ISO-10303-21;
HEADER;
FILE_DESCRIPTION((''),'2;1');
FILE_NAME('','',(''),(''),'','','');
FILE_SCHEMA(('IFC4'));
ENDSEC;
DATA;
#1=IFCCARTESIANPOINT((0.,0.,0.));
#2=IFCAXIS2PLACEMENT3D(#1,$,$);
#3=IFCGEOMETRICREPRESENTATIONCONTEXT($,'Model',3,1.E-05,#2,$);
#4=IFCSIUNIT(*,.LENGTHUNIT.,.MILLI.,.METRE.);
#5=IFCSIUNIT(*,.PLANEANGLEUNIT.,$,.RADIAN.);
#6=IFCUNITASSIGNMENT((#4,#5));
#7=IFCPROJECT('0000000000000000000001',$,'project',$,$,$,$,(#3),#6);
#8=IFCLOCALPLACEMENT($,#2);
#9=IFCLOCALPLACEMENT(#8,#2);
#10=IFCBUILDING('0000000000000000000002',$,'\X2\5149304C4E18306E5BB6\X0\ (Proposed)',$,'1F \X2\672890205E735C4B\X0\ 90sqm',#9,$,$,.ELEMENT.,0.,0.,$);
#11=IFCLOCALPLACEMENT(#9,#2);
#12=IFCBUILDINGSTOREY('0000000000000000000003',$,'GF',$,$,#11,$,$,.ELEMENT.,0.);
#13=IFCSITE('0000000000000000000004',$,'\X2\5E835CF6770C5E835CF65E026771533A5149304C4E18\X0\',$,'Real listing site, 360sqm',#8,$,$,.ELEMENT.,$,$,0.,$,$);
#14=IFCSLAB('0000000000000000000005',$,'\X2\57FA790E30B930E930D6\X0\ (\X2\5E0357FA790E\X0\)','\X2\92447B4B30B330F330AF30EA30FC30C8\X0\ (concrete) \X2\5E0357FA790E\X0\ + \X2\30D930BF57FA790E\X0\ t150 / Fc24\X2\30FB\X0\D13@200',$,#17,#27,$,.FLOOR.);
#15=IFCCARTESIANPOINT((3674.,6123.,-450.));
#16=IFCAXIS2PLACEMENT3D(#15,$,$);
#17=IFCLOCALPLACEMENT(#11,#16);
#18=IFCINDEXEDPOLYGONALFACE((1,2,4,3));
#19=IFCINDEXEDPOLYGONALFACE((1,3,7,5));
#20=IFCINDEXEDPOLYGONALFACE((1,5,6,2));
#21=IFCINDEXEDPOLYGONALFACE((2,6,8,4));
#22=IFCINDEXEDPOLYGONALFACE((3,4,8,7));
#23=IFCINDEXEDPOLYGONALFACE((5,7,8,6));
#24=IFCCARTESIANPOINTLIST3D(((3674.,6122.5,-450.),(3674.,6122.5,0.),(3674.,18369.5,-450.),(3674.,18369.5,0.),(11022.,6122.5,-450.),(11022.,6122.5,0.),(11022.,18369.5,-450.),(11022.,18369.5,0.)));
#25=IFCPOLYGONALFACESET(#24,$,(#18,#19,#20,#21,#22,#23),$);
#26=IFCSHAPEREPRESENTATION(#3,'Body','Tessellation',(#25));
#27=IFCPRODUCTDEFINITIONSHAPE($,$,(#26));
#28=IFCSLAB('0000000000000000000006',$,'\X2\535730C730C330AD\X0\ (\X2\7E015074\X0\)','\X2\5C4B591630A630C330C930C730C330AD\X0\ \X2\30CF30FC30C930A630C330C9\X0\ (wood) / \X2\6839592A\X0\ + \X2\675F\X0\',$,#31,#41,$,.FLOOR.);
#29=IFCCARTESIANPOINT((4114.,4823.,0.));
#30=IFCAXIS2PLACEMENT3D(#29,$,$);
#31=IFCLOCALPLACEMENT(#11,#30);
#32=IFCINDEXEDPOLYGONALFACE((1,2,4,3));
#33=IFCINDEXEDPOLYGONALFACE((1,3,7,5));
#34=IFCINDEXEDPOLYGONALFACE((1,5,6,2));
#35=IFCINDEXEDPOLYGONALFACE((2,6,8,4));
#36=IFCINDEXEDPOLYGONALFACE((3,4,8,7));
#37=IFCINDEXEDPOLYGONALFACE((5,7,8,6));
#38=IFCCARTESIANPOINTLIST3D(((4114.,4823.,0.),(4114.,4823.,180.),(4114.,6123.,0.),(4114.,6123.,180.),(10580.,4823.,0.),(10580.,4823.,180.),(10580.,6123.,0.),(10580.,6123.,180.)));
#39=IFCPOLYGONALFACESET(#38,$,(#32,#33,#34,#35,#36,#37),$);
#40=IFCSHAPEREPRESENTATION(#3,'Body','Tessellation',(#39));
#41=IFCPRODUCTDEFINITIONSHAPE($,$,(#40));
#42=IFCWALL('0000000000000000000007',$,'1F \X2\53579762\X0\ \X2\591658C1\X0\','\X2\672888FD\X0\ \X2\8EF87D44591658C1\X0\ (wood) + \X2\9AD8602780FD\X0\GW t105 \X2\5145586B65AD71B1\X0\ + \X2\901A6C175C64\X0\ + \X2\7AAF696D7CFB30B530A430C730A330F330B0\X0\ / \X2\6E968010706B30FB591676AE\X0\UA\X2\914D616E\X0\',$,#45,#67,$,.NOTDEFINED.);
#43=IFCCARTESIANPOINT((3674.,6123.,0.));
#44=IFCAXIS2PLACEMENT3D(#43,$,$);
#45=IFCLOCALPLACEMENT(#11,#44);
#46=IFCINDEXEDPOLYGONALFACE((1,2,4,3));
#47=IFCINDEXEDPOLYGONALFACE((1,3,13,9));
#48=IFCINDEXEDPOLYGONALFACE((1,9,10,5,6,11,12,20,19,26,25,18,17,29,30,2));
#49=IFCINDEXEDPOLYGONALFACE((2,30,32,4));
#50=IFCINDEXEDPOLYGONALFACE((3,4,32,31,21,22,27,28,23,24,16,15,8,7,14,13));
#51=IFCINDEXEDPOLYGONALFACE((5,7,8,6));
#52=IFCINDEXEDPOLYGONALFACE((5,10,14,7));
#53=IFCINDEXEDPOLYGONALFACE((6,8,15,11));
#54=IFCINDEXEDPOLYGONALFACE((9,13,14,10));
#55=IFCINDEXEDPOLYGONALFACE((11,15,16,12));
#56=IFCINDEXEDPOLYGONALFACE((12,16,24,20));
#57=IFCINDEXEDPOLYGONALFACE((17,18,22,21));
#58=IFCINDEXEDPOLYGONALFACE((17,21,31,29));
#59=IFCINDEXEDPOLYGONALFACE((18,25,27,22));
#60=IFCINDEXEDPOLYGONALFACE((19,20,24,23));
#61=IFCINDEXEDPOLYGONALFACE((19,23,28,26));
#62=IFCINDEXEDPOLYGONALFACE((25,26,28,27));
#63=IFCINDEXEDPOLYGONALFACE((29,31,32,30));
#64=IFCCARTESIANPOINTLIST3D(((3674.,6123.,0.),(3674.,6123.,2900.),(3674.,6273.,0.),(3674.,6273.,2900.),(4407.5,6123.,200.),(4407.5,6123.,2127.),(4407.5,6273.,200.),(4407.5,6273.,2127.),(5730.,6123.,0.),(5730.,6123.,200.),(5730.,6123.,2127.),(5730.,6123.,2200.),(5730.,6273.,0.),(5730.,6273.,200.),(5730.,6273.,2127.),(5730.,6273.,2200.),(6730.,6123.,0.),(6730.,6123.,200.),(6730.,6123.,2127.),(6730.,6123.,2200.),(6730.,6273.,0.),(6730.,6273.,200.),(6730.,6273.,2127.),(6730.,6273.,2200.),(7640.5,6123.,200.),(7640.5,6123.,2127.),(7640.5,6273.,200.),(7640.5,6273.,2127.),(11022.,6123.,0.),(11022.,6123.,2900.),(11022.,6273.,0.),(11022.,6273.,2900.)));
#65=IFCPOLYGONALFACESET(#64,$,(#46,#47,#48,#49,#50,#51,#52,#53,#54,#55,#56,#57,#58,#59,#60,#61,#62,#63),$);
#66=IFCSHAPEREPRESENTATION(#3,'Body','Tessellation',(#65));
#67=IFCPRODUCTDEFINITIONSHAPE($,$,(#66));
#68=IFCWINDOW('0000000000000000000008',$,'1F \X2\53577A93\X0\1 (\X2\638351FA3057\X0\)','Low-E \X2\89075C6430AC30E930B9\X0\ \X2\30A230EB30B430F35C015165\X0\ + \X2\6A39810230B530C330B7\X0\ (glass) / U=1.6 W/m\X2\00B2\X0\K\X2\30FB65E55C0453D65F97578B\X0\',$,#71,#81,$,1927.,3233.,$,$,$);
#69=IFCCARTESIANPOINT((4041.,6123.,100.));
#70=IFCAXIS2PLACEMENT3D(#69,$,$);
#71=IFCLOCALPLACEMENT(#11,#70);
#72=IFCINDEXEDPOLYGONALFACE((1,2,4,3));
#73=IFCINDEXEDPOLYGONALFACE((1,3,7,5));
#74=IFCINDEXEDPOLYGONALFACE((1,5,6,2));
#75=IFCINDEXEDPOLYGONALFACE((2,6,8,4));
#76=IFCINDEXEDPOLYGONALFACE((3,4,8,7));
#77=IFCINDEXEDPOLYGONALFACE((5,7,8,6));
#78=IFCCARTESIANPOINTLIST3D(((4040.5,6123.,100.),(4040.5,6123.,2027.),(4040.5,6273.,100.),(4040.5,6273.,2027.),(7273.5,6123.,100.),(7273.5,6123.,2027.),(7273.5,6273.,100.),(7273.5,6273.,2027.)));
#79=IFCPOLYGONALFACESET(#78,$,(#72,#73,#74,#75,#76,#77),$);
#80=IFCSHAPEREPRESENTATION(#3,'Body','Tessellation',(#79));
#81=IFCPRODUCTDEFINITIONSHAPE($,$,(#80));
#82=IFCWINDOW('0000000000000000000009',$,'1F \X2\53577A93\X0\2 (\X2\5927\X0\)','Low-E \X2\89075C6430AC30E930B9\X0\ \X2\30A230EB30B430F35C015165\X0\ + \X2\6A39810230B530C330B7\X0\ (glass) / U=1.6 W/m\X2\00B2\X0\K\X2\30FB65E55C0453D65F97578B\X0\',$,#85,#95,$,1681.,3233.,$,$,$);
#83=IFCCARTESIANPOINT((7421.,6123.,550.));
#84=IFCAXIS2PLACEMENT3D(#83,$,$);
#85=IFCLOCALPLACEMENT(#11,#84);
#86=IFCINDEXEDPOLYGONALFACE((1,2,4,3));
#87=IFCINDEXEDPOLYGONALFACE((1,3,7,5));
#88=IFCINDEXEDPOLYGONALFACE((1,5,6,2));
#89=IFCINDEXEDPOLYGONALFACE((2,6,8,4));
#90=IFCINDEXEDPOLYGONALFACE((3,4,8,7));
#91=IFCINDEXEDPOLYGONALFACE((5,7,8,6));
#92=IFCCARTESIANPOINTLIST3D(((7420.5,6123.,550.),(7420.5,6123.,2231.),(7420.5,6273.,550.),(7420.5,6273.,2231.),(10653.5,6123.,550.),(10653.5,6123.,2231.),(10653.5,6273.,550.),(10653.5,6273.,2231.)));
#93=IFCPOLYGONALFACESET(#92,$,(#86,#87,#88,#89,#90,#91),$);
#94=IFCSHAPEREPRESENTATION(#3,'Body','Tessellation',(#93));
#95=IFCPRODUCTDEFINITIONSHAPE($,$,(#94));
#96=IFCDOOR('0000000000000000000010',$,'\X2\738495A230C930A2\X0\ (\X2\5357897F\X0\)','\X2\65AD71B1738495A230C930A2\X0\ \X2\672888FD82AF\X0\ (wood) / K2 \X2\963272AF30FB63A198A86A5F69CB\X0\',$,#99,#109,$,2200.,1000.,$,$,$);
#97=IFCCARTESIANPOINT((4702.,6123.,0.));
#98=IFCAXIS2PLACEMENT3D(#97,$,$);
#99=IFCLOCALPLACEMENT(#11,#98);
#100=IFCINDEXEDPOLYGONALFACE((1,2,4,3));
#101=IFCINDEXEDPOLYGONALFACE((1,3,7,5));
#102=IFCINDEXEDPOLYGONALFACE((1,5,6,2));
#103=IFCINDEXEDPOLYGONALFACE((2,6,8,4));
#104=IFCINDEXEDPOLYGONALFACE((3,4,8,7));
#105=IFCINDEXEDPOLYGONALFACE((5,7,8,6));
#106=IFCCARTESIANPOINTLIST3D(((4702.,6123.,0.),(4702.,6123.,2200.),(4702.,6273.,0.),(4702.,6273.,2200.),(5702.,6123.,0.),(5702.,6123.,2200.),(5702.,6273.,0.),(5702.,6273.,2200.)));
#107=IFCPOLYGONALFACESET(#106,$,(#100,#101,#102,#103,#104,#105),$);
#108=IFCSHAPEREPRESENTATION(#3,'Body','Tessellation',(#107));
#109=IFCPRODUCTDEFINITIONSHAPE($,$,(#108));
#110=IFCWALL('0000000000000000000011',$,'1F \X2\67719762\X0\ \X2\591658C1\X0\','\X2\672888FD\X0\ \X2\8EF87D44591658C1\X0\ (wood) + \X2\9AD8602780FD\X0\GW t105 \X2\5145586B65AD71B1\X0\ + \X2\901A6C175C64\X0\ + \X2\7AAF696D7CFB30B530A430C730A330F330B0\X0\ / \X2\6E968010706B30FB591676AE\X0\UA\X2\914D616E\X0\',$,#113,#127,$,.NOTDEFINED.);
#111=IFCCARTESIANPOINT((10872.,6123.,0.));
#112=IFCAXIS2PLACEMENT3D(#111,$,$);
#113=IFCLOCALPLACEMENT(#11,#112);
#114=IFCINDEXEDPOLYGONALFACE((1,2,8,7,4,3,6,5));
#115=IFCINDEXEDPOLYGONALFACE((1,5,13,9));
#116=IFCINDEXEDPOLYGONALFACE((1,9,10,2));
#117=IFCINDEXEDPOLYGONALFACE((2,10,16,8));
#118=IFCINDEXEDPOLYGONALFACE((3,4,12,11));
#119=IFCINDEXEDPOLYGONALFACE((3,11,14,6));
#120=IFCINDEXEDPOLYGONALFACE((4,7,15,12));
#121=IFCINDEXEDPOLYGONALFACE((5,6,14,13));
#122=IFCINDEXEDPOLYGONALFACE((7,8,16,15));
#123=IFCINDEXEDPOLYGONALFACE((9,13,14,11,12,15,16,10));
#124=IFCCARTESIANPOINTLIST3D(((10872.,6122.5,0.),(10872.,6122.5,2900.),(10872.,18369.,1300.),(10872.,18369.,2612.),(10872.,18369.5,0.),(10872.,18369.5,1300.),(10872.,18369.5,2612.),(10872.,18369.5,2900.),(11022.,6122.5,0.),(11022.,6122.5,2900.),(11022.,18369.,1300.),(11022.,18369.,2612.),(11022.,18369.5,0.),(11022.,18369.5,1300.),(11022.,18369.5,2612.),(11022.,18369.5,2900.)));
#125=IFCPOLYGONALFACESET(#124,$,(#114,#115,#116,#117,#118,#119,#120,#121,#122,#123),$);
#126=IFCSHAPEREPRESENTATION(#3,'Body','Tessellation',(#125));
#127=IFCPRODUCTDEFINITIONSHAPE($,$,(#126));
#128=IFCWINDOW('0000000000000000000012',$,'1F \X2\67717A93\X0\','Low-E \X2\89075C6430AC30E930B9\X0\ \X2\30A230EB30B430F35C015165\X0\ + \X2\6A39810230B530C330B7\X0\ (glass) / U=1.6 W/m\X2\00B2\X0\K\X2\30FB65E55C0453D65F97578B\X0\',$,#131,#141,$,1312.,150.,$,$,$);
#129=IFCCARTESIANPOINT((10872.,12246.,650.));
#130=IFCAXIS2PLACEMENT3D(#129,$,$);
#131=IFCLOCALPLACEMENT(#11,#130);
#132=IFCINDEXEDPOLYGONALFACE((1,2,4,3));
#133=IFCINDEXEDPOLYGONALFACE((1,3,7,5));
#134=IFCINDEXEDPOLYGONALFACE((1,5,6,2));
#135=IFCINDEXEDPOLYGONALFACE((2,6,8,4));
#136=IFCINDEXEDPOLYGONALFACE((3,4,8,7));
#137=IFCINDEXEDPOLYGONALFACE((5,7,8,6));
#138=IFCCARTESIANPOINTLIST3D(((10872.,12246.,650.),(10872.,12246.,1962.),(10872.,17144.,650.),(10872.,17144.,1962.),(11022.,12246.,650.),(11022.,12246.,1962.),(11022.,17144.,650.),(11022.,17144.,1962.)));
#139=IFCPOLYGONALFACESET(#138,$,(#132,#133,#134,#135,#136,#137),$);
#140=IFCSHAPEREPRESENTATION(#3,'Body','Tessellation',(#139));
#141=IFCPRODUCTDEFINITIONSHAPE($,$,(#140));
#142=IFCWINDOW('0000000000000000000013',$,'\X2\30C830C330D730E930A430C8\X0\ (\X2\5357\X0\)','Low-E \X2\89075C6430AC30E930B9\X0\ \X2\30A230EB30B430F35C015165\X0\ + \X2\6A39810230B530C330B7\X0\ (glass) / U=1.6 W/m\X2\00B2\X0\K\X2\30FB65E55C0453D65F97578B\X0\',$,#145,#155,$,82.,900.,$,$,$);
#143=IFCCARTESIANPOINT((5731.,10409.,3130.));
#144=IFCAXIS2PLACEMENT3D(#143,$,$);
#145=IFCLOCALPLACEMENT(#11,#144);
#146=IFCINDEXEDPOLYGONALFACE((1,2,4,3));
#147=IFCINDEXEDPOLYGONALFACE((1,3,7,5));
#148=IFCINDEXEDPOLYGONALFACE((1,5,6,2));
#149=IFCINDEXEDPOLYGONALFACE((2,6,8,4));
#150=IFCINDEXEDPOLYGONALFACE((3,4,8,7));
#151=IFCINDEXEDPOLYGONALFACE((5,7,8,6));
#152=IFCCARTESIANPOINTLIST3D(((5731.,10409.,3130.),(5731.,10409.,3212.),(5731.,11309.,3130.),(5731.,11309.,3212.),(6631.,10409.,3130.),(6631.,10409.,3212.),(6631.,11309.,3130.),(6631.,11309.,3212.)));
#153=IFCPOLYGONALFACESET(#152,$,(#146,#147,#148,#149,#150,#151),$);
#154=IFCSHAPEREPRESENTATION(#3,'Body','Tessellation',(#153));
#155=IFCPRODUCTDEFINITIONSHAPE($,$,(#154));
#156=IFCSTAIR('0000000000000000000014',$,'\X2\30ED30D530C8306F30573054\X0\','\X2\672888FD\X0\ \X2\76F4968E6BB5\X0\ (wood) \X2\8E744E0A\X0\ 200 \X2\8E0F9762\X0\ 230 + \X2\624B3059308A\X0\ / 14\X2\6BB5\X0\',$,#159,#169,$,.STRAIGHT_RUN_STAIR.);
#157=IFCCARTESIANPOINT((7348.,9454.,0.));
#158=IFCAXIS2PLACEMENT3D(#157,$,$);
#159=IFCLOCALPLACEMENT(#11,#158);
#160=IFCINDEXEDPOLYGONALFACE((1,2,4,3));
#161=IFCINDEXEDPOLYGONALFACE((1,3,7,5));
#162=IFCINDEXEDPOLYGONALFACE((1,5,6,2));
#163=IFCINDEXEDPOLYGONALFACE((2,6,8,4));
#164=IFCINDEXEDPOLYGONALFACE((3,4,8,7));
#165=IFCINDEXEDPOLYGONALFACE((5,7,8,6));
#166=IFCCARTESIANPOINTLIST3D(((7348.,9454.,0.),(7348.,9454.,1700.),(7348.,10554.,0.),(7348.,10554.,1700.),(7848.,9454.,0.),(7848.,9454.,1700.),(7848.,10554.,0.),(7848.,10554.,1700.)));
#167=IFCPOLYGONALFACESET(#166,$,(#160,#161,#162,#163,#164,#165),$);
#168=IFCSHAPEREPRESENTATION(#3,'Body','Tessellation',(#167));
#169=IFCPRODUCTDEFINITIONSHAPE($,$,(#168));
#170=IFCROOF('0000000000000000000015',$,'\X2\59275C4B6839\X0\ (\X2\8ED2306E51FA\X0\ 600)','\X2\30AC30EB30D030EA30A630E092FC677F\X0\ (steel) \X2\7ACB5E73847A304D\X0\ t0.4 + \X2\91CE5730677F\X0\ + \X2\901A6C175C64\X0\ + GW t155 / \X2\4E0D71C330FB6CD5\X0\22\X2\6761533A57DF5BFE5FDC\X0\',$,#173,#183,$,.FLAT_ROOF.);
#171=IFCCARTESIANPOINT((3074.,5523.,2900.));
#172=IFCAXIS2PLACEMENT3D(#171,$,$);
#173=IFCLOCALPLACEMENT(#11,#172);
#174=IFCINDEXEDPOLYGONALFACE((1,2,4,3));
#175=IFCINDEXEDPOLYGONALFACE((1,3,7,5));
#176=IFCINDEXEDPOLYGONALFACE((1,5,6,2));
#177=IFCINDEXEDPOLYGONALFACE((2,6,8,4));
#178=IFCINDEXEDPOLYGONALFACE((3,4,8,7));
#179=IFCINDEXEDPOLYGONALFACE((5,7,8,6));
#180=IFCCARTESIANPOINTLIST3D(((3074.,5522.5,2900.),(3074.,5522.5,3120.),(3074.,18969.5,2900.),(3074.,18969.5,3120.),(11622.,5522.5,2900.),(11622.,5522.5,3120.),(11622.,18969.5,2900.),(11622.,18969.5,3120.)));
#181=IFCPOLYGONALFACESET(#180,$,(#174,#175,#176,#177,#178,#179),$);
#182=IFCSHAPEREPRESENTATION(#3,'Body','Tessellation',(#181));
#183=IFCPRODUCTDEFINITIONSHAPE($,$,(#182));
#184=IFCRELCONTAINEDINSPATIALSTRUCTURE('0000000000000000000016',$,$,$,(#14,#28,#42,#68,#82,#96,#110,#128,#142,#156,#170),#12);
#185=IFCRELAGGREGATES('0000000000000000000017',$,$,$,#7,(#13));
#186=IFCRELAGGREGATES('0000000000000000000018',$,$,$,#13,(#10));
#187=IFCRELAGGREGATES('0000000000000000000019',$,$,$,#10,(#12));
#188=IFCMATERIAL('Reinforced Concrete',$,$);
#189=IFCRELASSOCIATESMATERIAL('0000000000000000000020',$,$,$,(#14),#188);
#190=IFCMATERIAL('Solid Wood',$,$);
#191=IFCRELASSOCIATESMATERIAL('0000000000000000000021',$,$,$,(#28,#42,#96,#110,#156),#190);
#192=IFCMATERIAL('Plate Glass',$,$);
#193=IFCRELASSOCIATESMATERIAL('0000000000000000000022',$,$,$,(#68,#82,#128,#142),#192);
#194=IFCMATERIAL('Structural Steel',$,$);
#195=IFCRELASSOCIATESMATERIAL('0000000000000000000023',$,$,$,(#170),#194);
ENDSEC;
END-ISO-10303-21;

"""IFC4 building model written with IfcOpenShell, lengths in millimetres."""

from ifc_helpers import new_model, si_unit, frame, frame_2d, origin, place, context, project, spatial, rectangle, extrude, material, element, fill, save


model = new_model("IFC4")

# Units and contexts
model_context = context("Model", 3, precision=1e-05, world=origin())
ifc_project = project(units=[si_unit("LENGTHUNIT", "METRE", prefix="MILLI"), si_unit("PLANEANGLEUNIT", "RADIAN")], contexts=[model_context])

# Site, building, storey
site_placement = place(None, origin())
site = spatial("IfcSite", under=ifc_project, at=site_placement, Name="広島県広島市東区光が丘", ObjectType="Real listing site, 360sqm", CompositionType="ELEMENT", RefElevation=0.0)
building_placement = place(site_placement, origin())
building = spatial("IfcBuilding", under=site, at=building_placement, Name="光が丘の家 (Proposed)", ObjectType="1F 木造平屋 90sqm", CompositionType="ELEMENT", ElevationOfRefHeight=0.0, ElevationOfTerrain=0.0)
storey_placement = place(building_placement, origin())
storey = spatial("IfcBuildingStorey", under=building, at=storey_placement, Name="GF", CompositionType="ELEMENT", Elevation=0.0)

# Slabs
ifc_material_1 = material(Name="Reinforced Concrete")
slab_1_placement = place(storey_placement, frame((3674.0, 6123.0, -450.0)))
element("IfcSlab", 1, at=slab_1_placement, inside=storey, material=ifc_material_1, Name="基礎スラブ (布基礎)", Description="鉄筋コンクリート (concrete) 布基礎 + ベタ基礎 t150 / Fc24・D13@200", PredefinedType="FLOOR", context=model_context, shape_type="SweptSolid", body=[
    extrude(rectangle(XDim=7348.0, YDim=12247.0, at=frame_2d((3674.0, 6123.0))), frame((3674.0, 6123.0, -450.0)), (0.0, 0.0, 1.0), 450.0),
])
ifc_material_2 = material(Name="Solid Wood")
slab_2_placement = place(storey_placement, frame((4114.0, 4823.0, 0.0)))
element("IfcSlab", 2, at=slab_2_placement, inside=storey, material=ifc_material_2, Name="南デッキ (縁側)", Description="屋外ウッドデッキ ハードウッド (wood) / 根太 + 束", PredefinedType="FLOOR", context=model_context, shape_type="SweptSolid", body=[
    extrude(rectangle(XDim=6466.0, YDim=1300.0, at=frame_2d((3233.0, 650.0))), frame((4114.0, 4823.0, 0.0)), (0.0, 0.0, 1.0), 180.0),
])

# Wall, openings, windows, door
wall_1_placement = place(storey_placement, frame((3674.0, 6123.0, 0.0)))
wall_1 = element("IfcWall", 3, at=wall_1_placement, inside=storey, material=ifc_material_2, Name="1F 南面 外壁", Description="木製 軸組外壁 (wood) + 高性能GW t105 充填断熱 + 通気層 + 窯業系サイディング / 準耐火・外皮UA配慮", PredefinedType="NOTDEFINED", context=model_context, shape_type="SweptSolid", body=[
    extrude(rectangle(XDim=7348.0, YDim=150.0, at=frame_2d((3674.0, 75.0))), frame((3674.0, 6123.0, 0.0)), (0.0, 0.0, 1.0), 2900.0),
])
opening_1_placement = place(storey_placement, frame((4041.0, 6123.0, 100.0)))
opening_1 = element("IfcOpeningElement", 4, at=opening_1_placement, cuts=wall_1, PredefinedType="NOTDEFINED", context=model_context, shape_type="SweptSolid", body=[
    extrude(rectangle(XDim=3233.0, YDim=150.0, at=frame_2d((1616.0, 75.0))), frame((4041.0, 6123.0, 100.0)), (0.0, 0.0, 1.0), 1927.0),
])
opening_2_placement = place(storey_placement, frame((7421.0, 6123.0, 550.0)))
opening_2 = element("IfcOpeningElement", 5, at=opening_2_placement, cuts=wall_1, PredefinedType="NOTDEFINED", context=model_context, shape_type="SweptSolid", body=[
    extrude(rectangle(XDim=3233.0, YDim=150.0, at=frame_2d((1616.0, 75.0))), frame((7421.0, 6123.0, 550.0)), (0.0, 0.0, 1.0), 1681.0),
])
opening_3_placement = place(storey_placement, frame((4702.0, 6123.0, 0.0)))
opening_3 = element("IfcOpeningElement", 6, at=opening_3_placement, cuts=wall_1, PredefinedType="NOTDEFINED", context=model_context, shape_type="SweptSolid", body=[
    extrude(rectangle(XDim=1000.0, YDim=150.0, at=frame_2d((500.0, 75.0))), frame((4702.0, 6123.0, 0.0)), (0.0, 0.0, 1.0), 2200.0),
])
ifc_material_3 = material(Name="Plate Glass")
window_1_placement = place(storey_placement, frame((4041.0, 6123.0, 100.0)))
window_1 = element("IfcWindow", 7, at=window_1_placement, inside=storey, material=ifc_material_3, Name="1F 南窓1 (掃出し)", Description="Low-E 複層ガラス アルゴン封入 + 樹脂サッシ (glass) / U=1.6 W/m²K・日射取得型", OverallHeight=1927.0, OverallWidth=3233.0, context=model_context, shape_type="SweptSolid", body=[
    extrude(rectangle(XDim=3233.0, YDim=150.0, at=frame_2d((1616.0, 75.0))), frame((4041.0, 6123.0, 100.0)), (0.0, 0.0, 1.0), 1927.0),
])
fill(opening_1, window_1)
window_2_placement = place(storey_placement, frame((7421.0, 6123.0, 550.0)))
window_2 = element("IfcWindow", 8, at=window_2_placement, inside=storey, material=ifc_material_3, Name="1F 南窓2 (大)", Description="Low-E 複層ガラス アルゴン封入 + 樹脂サッシ (glass) / U=1.6 W/m²K・日射取得型", OverallHeight=1681.0, OverallWidth=3233.0, context=model_context, shape_type="SweptSolid", body=[
    extrude(rectangle(XDim=3233.0, YDim=150.0, at=frame_2d((1616.0, 75.0))), frame((7421.0, 6123.0, 550.0)), (0.0, 0.0, 1.0), 1681.0),
])
fill(opening_2, window_2)
door_placement = place(storey_placement, frame((4702.0, 6123.0, 0.0)))
door = element("IfcDoor", 9, at=door_placement, inside=storey, material=ifc_material_2, Name="玄関ドア (南西)", Description="断熱玄関ドア 木製芯 (wood) / K2 防犯・採風機構", OverallHeight=2200.0, OverallWidth=1000.0, context=model_context, shape_type="SweptSolid", body=[
    extrude(rectangle(XDim=1000.0, YDim=150.0, at=frame_2d((500.0, 75.0))), frame((4702.0, 6123.0, 0.0)), (0.0, 0.0, 1.0), 2200.0),
])
fill(opening_3, door)

# Wall, opening, window
wall_2_placement = place(storey_placement, frame((10872.0, 6123.0, 0.0)))
wall_2 = element("IfcWall", 10, at=wall_2_placement, inside=storey, material=ifc_material_2, Name="1F 東面 外壁", Description="木製 軸組外壁 (wood) + 高性能GW t105 充填断熱 + 通気層 + 窯業系サイディング / 準耐火・外皮UA配慮", PredefinedType="NOTDEFINED", context=model_context, shape_type="SweptSolid", body=[
    extrude(rectangle(XDim=150.0, YDim=12247.0, at=frame_2d((75.0, 6123.0))), frame((10872.0, 6123.0, 0.0)), (0.0, 0.0, 1.0), 2900.0),
])
opening_4_placement = place(storey_placement, frame((10872.0, 12246.0, 650.0)))
opening_4 = element("IfcOpeningElement", 11, at=opening_4_placement, cuts=wall_2, PredefinedType="NOTDEFINED", context=model_context, shape_type="SweptSolid", body=[
    extrude(rectangle(XDim=150.0, YDim=4898.0, at=frame_2d((75.0, 2449.0))), frame((10872.0, 12246.0, 650.0)), (0.0, 0.0, 1.0), 1312.0),
])
window_3_placement = place(storey_placement, frame((10872.0, 12246.0, 650.0)))
window_3 = element("IfcWindow", 12, at=window_3_placement, inside=storey, material=ifc_material_3, Name="1F 東窓", Description="Low-E 複層ガラス アルゴン封入 + 樹脂サッシ (glass) / U=1.6 W/m²K・日射取得型", OverallHeight=1312.0, OverallWidth=150.0, context=model_context, shape_type="SweptSolid", body=[
    extrude(rectangle(XDim=150.0, YDim=4898.0, at=frame_2d((75.0, 2449.0))), frame((10872.0, 12246.0, 650.0)), (0.0, 0.0, 1.0), 1312.0),
])
fill(opening_4, window_3)

# Window
window_4_placement = place(storey_placement, frame((5731.0, 10409.0, 3130.0)))
element("IfcWindow", 13, at=window_4_placement, inside=storey, material=ifc_material_3, Name="トップライト (南)", Description="Low-E 複層ガラス アルゴン封入 + 樹脂サッシ (glass) / U=1.6 W/m²K・日射取得型", OverallHeight=82.0, OverallWidth=900.0, context=model_context, shape_type="SweptSolid", body=[
    extrude(rectangle(XDim=900.0, YDim=900.0, at=frame_2d((450.0, 450.0))), frame((5731.0, 10409.0, 3130.0)), (0.0, 0.0, 1.0), 82.0),
])

# Stair
stair_placement = place(storey_placement, frame((7348.0, 9454.0, 0.0)))
element("IfcStair", 14, at=stair_placement, inside=storey, material=ifc_material_2, Name="ロフトはしご", Description="木製 直階段 (wood) 蹴上 200 踏面 230 + 手すり / 14段", PredefinedType="STRAIGHT_RUN_STAIR", context=model_context, shape_type="SweptSolid", body=[
    extrude(rectangle(XDim=500.0, YDim=1100.0, at=frame_2d((250.0, 550.0))), frame((7348.0, 9454.0, 0.0)), (0.0, 0.0, 1.0), 1700.0),
])

# Roof
ifc_material_4 = material(Name="Structural Steel")
roof_placement = place(storey_placement, frame((3074.0, 5523.0, 2900.0)))
element("IfcRoof", 15, at=roof_placement, inside=storey, material=ifc_material_4, Name="大屋根 (軒の出 600)", Description="ガルバリウム鋼板 (steel) 立平葺き t0.4 + 野地板 + 通気層 + GW t155 / 不燃・法22条区域対応", PredefinedType="FLAT_ROOF", context=model_context, shape_type="SweptSolid", body=[
    extrude(rectangle(XDim=8548.0, YDim=13447.0, at=frame_2d((4274.0, 6723.0))), frame((3074.0, 5523.0, 2900.0)), (0.0, 0.0, 1.0), 220.0),
])

save(model, "model.ifc")
